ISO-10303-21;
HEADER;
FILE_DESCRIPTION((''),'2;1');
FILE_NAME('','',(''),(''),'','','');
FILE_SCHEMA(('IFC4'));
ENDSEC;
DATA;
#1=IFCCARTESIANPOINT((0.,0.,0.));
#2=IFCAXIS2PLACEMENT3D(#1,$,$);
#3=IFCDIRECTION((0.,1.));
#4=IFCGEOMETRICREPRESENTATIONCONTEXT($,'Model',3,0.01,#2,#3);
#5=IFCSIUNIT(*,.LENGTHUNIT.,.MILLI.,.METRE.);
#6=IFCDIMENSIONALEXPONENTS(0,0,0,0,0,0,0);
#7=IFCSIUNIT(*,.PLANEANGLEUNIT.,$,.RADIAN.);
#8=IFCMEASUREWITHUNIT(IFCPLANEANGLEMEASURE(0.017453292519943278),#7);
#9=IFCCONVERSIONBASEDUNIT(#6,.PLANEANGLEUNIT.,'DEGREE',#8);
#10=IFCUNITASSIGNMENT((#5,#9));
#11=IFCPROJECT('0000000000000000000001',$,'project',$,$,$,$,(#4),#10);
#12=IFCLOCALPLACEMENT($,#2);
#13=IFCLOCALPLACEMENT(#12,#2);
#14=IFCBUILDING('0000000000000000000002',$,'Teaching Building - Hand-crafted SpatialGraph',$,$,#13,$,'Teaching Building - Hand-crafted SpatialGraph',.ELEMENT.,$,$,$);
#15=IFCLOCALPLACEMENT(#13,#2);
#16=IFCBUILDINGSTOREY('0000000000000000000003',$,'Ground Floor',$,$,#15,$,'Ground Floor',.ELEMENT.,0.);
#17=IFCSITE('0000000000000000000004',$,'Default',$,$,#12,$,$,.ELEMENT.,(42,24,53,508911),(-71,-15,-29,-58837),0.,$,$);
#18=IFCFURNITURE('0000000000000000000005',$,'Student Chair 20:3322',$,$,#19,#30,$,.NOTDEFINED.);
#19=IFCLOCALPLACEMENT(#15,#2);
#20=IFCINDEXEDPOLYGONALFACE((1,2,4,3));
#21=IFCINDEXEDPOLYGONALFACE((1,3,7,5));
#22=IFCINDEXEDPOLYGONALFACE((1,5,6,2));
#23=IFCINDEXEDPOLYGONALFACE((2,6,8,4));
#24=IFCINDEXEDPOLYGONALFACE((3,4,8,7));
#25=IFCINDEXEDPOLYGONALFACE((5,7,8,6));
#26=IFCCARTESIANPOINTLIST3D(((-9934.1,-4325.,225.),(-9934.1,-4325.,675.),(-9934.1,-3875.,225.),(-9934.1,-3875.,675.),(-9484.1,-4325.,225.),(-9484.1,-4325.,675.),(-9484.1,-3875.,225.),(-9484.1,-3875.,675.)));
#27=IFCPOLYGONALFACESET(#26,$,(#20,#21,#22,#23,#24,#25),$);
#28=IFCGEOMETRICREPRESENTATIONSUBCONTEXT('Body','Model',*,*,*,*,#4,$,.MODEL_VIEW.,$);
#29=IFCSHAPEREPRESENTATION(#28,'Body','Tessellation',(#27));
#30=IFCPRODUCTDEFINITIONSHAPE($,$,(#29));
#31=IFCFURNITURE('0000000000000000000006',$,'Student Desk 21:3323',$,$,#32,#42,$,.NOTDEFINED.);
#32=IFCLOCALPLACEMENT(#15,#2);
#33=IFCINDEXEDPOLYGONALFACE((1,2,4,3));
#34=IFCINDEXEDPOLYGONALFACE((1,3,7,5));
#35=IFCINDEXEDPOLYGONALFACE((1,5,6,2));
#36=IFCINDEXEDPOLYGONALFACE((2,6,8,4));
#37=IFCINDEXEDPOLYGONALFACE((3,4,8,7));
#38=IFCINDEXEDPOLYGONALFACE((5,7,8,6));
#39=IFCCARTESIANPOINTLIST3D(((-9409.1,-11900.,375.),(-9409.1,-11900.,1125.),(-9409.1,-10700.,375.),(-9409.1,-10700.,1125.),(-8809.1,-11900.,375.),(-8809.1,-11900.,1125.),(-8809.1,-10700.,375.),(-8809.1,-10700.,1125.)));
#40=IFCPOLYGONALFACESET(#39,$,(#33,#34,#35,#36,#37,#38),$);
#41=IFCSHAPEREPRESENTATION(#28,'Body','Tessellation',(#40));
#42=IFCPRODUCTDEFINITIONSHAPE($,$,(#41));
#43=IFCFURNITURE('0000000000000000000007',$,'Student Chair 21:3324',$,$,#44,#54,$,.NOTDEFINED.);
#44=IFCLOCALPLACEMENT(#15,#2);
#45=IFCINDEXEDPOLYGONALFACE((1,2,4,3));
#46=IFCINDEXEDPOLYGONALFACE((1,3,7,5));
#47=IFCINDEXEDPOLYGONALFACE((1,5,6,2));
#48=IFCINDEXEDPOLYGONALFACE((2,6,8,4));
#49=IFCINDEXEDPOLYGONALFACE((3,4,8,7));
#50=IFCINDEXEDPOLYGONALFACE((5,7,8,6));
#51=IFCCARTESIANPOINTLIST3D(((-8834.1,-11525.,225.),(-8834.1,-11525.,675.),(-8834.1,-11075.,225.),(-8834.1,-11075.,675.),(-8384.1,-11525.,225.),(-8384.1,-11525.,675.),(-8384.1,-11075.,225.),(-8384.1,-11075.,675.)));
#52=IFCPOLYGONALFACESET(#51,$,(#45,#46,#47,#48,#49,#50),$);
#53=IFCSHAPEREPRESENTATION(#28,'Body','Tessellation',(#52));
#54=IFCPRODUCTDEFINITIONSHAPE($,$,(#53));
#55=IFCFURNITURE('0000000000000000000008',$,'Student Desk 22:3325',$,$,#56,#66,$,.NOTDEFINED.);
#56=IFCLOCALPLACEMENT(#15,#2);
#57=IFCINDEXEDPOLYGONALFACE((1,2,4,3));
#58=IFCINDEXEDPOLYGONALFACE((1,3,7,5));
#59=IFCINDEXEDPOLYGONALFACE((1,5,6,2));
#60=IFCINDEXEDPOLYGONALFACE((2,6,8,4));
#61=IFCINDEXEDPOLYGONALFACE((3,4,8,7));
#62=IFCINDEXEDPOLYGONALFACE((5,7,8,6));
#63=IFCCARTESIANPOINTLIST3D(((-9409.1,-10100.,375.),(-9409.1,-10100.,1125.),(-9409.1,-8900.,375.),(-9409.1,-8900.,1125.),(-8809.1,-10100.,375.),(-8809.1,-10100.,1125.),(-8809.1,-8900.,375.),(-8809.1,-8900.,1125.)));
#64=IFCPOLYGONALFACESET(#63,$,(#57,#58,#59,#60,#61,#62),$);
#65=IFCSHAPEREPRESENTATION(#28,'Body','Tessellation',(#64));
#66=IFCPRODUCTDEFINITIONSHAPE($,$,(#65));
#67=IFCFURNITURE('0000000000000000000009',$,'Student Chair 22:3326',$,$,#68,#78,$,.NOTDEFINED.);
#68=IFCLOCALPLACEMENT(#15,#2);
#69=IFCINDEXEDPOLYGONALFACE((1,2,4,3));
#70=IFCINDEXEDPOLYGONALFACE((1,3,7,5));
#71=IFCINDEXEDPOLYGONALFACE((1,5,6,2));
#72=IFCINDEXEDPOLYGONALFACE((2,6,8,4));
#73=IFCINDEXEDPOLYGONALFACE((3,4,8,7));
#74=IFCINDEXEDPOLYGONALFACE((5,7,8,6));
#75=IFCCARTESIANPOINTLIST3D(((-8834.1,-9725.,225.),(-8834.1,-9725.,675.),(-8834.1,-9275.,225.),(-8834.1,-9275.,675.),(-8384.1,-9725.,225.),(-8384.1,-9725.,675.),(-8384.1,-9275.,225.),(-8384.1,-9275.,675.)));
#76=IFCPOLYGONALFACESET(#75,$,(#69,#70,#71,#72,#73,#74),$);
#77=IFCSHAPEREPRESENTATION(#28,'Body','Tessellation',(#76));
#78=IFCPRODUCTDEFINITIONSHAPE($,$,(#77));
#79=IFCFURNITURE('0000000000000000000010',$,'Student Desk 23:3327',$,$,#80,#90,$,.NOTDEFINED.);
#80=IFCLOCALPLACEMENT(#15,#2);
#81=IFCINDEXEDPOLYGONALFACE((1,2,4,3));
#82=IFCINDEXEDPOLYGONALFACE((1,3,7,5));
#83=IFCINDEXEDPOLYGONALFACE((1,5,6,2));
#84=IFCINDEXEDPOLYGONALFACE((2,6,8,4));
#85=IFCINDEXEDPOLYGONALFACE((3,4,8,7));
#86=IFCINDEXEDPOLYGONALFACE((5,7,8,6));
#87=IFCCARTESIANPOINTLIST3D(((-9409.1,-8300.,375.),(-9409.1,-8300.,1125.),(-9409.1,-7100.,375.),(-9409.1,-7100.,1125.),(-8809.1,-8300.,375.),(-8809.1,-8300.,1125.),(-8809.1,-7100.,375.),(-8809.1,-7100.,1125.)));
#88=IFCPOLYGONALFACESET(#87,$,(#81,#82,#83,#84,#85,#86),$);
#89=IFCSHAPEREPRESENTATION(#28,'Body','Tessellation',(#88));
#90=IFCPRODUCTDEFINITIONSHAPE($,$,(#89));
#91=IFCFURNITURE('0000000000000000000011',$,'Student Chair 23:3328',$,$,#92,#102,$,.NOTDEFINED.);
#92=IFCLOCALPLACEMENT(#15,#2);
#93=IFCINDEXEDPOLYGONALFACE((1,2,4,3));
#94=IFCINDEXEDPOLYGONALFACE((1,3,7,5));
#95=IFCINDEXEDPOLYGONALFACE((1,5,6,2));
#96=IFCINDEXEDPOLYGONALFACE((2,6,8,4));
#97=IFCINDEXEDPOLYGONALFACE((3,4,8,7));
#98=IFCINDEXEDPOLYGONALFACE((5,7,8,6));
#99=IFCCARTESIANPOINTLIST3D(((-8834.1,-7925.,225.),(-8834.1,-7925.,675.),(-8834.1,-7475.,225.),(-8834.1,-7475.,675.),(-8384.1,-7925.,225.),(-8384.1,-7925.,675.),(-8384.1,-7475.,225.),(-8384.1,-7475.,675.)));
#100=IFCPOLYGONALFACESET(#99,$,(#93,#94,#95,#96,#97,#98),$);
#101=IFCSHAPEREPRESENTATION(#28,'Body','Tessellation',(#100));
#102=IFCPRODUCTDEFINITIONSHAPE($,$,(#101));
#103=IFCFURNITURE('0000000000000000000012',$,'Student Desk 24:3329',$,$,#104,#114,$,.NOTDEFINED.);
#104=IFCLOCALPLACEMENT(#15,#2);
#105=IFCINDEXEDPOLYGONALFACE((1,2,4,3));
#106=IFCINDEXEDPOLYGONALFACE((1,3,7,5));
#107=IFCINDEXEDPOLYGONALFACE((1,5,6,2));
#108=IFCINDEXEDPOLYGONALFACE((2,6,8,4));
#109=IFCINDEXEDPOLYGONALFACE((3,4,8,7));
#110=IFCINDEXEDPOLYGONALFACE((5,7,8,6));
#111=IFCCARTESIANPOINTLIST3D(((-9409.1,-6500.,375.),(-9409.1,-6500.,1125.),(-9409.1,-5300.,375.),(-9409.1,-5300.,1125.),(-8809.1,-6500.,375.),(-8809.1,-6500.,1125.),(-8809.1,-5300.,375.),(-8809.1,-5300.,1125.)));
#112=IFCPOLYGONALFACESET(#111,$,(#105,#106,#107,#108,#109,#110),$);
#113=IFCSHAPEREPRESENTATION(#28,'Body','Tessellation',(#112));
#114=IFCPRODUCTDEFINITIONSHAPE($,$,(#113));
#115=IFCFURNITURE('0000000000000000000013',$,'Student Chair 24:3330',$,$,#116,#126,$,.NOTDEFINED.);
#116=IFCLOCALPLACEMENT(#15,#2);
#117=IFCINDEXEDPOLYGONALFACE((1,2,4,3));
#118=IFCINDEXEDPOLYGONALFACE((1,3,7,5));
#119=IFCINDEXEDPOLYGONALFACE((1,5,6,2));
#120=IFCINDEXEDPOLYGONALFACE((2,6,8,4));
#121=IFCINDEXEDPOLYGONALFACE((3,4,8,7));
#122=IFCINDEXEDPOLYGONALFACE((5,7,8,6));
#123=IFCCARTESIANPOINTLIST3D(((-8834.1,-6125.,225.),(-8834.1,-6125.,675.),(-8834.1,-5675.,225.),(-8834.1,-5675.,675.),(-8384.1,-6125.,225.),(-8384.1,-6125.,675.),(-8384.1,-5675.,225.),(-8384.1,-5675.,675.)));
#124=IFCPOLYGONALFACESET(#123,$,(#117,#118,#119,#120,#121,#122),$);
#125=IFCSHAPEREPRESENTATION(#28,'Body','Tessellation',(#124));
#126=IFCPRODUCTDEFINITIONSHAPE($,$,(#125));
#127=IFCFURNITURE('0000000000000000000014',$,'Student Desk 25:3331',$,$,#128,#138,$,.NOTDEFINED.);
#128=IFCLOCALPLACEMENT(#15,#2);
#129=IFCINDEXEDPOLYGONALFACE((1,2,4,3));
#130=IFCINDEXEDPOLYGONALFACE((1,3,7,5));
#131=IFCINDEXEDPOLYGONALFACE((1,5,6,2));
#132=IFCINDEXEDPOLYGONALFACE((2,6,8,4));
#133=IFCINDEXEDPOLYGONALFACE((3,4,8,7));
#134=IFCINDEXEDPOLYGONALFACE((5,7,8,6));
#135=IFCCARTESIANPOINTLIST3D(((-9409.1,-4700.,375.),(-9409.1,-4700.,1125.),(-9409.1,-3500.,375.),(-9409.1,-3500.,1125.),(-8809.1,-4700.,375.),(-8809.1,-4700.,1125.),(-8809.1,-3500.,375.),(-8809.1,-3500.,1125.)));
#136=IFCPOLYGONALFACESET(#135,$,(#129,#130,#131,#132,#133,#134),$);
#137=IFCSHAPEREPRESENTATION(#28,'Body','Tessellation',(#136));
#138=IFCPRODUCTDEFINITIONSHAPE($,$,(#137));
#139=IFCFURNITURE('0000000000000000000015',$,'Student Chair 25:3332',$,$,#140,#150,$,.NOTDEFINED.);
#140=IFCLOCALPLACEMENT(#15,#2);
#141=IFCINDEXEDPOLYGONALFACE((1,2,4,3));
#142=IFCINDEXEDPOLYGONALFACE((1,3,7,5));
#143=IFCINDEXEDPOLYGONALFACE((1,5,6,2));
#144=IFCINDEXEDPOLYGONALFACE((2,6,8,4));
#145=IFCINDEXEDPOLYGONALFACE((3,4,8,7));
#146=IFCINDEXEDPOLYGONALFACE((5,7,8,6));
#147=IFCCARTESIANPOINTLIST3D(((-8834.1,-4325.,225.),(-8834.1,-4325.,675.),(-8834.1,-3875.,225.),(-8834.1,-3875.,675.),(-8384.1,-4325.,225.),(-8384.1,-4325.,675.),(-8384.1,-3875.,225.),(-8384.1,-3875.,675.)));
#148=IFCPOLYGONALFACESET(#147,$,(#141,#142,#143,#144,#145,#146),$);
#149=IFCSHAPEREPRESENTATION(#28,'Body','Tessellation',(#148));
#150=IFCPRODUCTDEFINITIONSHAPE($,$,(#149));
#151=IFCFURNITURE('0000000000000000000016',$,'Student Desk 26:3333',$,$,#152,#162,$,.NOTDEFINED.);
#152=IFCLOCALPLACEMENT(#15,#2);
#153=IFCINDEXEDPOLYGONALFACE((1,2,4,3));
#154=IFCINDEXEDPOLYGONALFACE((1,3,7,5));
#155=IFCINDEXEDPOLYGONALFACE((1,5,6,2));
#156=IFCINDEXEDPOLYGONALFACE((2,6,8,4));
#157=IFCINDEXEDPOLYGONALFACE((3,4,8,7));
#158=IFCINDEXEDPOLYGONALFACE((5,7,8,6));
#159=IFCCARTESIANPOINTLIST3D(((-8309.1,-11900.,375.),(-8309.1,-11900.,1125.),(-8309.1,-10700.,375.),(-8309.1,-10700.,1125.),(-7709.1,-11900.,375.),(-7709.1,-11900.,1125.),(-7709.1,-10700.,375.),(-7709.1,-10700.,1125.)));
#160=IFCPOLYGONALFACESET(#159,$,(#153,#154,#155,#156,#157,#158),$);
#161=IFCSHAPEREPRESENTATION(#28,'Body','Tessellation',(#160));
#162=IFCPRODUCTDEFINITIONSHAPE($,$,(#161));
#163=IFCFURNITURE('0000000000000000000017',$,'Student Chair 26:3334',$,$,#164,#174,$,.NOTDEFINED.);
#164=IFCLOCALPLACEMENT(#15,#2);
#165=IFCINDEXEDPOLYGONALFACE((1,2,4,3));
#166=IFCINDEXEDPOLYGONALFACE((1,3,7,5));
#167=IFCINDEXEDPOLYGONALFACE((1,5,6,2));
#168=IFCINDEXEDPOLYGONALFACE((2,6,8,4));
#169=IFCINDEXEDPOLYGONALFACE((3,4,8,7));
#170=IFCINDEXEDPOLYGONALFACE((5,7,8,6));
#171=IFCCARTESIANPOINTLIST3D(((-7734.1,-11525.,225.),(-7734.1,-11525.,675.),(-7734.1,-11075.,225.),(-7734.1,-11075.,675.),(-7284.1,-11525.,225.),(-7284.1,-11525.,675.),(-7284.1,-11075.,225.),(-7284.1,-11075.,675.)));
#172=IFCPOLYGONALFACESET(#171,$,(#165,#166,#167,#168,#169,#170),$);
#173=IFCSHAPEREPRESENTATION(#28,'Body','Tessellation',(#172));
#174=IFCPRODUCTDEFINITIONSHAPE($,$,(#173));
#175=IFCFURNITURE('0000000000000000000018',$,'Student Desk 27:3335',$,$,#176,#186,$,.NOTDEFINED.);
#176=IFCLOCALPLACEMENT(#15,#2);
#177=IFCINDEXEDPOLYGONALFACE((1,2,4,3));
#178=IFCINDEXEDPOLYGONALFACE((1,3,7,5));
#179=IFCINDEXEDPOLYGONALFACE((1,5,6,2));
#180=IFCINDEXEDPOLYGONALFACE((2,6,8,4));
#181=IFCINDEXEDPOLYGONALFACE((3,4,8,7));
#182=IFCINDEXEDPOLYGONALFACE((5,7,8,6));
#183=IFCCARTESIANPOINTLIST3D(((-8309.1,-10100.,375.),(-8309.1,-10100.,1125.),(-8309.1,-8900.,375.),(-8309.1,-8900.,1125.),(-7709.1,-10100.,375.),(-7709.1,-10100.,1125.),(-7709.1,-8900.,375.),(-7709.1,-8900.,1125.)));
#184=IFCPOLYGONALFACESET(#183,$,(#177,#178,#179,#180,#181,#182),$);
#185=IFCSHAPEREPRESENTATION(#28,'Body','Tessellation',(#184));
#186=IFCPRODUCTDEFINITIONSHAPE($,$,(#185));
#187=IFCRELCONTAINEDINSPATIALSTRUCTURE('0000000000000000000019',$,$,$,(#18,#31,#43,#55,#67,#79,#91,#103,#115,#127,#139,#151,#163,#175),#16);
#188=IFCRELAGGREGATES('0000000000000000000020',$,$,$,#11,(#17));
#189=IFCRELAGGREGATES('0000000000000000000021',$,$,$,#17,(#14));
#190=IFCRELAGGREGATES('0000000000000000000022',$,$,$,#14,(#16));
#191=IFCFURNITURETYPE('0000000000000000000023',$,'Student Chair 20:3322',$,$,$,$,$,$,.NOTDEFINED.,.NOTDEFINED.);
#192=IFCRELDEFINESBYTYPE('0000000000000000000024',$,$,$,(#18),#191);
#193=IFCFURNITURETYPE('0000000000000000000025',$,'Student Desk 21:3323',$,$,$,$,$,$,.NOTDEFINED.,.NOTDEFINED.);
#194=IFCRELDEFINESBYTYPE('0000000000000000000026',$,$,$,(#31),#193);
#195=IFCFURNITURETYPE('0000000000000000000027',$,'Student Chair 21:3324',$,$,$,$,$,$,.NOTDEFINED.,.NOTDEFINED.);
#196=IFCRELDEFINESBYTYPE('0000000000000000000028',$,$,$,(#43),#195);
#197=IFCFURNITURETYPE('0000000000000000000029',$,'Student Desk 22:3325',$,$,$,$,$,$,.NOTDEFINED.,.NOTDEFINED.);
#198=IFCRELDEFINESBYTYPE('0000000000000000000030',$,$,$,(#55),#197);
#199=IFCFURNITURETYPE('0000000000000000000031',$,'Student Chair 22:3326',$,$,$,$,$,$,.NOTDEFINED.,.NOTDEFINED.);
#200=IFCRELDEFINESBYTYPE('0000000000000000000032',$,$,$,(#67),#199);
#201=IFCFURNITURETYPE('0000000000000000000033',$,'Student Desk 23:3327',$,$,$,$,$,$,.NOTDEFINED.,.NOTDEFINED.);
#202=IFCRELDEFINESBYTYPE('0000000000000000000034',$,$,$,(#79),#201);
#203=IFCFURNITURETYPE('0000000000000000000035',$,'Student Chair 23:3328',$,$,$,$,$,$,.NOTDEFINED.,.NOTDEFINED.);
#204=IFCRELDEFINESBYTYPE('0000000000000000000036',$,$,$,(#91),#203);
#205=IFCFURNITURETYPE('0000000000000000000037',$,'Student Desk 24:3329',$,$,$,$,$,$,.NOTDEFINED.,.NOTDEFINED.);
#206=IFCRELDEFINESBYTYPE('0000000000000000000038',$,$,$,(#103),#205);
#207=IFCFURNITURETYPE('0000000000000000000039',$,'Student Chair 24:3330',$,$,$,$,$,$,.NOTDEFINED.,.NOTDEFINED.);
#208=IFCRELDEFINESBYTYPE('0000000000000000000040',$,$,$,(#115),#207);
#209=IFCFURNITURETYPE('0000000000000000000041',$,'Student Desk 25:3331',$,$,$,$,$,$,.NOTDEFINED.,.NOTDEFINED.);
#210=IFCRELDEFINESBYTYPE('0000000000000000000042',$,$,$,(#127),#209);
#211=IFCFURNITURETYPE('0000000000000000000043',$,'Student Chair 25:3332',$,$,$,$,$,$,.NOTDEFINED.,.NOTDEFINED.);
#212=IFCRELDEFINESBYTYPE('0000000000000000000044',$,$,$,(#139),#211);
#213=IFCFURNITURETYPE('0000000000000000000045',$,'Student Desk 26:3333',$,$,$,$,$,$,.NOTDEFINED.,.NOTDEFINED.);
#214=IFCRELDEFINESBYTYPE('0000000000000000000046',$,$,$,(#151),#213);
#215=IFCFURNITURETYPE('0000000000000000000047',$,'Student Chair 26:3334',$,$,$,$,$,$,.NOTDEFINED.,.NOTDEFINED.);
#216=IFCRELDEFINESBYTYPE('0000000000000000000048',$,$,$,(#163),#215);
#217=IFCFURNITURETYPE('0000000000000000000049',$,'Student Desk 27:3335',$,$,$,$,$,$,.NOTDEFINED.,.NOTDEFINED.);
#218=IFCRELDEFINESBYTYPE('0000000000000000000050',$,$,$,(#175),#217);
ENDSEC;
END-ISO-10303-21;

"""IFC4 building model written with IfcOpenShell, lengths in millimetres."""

from ifc_helpers import new_model, entity, si_unit, converted_unit, direction, frame, frame_2d, origin, origin_2d_with_axis, place, context, subcontext, project, spatial, rectangle, extrude, type_object, element, save


model = new_model("IFC4")

# Units and contexts
model_context = context("Model", 3, precision=0.01, world=origin(), true_north=direction((0.0, 1.0)))
body_context = subcontext(model_context, "Body", "Model", "MODEL_VIEW")
ifc_project = project(units=[si_unit("LENGTHUNIT", "METRE", prefix="MILLI"), converted_unit("PLANEANGLEUNIT", "DEGREE", entity("IfcPlaneAngleMeasure", 0.017453292519943278), si_unit("PLANEANGLEUNIT", "RADIAN"), dimensions=[0, 0, 0, 0, 0, 0, 0])], contexts=[model_context])

# Site, building, storey
site_placement = place(None, origin())
site = spatial("IfcSite", under=ifc_project, at=site_placement, Name="Default", CompositionType="ELEMENT", RefLatitude=(42, 24, 53, 508911), RefLongitude=(-71, -15, -29, -58837), RefElevation=0.0)
building_placement = place(site_placement, origin())
building = spatial("IfcBuilding", under=site, at=building_placement, Name="Teaching Building - Hand-crafted SpatialGraph", LongName="Teaching Building - Hand-crafted SpatialGraph", CompositionType="ELEMENT")
storey_placement = place(building_placement, origin())
storey = spatial("IfcBuildingStorey", under=building, at=storey_placement, Name="Ground Floor", LongName="Ground Floor", CompositionType="ELEMENT", Elevation=0.0)

# Furniture
furniture_type_1 = type_object("IfcFurnitureType", Name="Student Chair 20:3322", PredefinedType="NOTDEFINED")
furniture_1_placement = place(storey_placement, origin())
element("IfcFurniture", 1, at=furniture_1_placement, inside=storey, type_object=furniture_type_1, Name="Student Chair 20:3322", PredefinedType="NOTDEFINED", context=body_context, shape_type="SweptSolid", body=[
    extrude(rectangle(XDim=450.0, YDim=450.0, at=frame_2d((0.0, 0.0), x_axis=(1.0, 0.0))), frame((-9709.1, -4100.0, 225.0)), (0.0, 0.0, 1.0), 450.0),
])
furniture_type_2 = type_object("IfcFurnitureType", Name="Student Desk 21:3323", PredefinedType="NOTDEFINED")
furniture_2_placement = place(storey_placement, origin())
element("IfcFurniture", 2, at=furniture_2_placement, inside=storey, type_object=furniture_type_2, Name="Student Desk 21:3323", PredefinedType="NOTDEFINED", context=body_context, shape_type="SweptSolid", body=[
    extrude(rectangle(XDim=1200.0, YDim=600.0, at=origin_2d_with_axis()), frame((-9109.1, -11300.0, 375.0), z_axis=(0.0, 0.0, 1.0), x_axis=(0.0, 1.0, 0.0)), (0.0, 0.0, 1.0), 750.0),
])
furniture_type_3 = type_object("IfcFurnitureType", Name="Student Chair 21:3324", PredefinedType="NOTDEFINED")
furniture_3_placement = place(storey_placement, origin())
element("IfcFurniture", 3, at=furniture_3_placement, inside=storey, type_object=furniture_type_3, Name="Student Chair 21:3324", PredefinedType="NOTDEFINED", context=body_context, shape_type="SweptSolid", body=[
    extrude(rectangle(XDim=450.0, YDim=450.0, at=origin_2d_with_axis()), frame((-8609.1, -11300.0, 225.0)), (0.0, 0.0, 1.0), 450.0),
])
furniture_type_4 = type_object("IfcFurnitureType", Name="Student Desk 22:3325", PredefinedType="NOTDEFINED")
furniture_4_placement = place(storey_placement, origin())
element("IfcFurniture", 4, at=furniture_4_placement, inside=storey, type_object=furniture_type_4, Name="Student Desk 22:3325", PredefinedType="NOTDEFINED", context=body_context, shape_type="SweptSolid", body=[
    extrude(rectangle(XDim=1200.0, YDim=600.0, at=origin_2d_with_axis()), frame((-9109.1, -9500.0, 375.0), z_axis=(0.0, 0.0, 1.0), x_axis=(0.0, 1.0, 0.0)), (0.0, 0.0, 1.0), 750.0),
])
furniture_type_5 = type_object("IfcFurnitureType", Name="Student Chair 22:3326", PredefinedType="NOTDEFINED")
furniture_5_placement = place(storey_placement, origin())
element("IfcFurniture", 5, at=furniture_5_placement, inside=storey, type_object=furniture_type_5, Name="Student Chair 22:3326", PredefinedType="NOTDEFINED", context=body_context, shape_type="SweptSolid", body=[
    extrude(rectangle(XDim=450.0, YDim=450.0, at=origin_2d_with_axis()), frame((-8609.1, -9500.0, 225.0)), (0.0, 0.0, 1.0), 450.0),
])
furniture_type_6 = type_object("IfcFurnitureType", Name="Student Desk 23:3327", PredefinedType="NOTDEFINED")
furniture_6_placement = place(storey_placement, origin())
element("IfcFurniture", 6, at=furniture_6_placement, inside=storey, type_object=furniture_type_6, Name="Student Desk 23:3327", PredefinedType="NOTDEFINED", context=body_context, shape_type="SweptSolid", body=[
    extrude(rectangle(XDim=1200.0, YDim=600.0, at=origin_2d_with_axis()), frame((-9109.1, -7700.0, 375.0), z_axis=(0.0, 0.0, 1.0), x_axis=(0.0, 1.0, 0.0)), (0.0, 0.0, 1.0), 750.0),
])
furniture_type_7 = type_object("IfcFurnitureType", Name="Student Chair 23:3328", PredefinedType="NOTDEFINED")
furniture_7_placement = place(storey_placement, origin())
element("IfcFurniture", 7, at=furniture_7_placement, inside=storey, type_object=furniture_type_7, Name="Student Chair 23:3328", PredefinedType="NOTDEFINED", context=body_context, shape_type="SweptSolid", body=[
    extrude(rectangle(XDim=450.0, YDim=450.0, at=frame_2d((0.0, 0.0), x_axis=(1.0, 0.0))), frame((-8609.1, -7700.0, 225.0)), (0.0, 0.0, 1.0), 450.0),
])
furniture_type_8 = type_object("IfcFurnitureType", Name="Student Desk 24:3329", PredefinedType="NOTDEFINED")
furniture_8_placement = place(storey_placement, origin())
element("IfcFurniture", 8, at=furniture_8_placement, inside=storey, type_object=furniture_type_8, Name="Student Desk 24:3329", PredefinedType="NOTDEFINED", context=body_context, shape_type="SweptSolid", body=[
    extrude(rectangle(XDim=1200.0, YDim=600.0, at=origin_2d_with_axis()), frame((-9109.1, -5900.0, 375.0), z_axis=(0.0, 0.0, 1.0), x_axis=(0.0, 1.0, 0.0)), (0.0, 0.0, 1.0), 750.0),
])
furniture_type_9 = type_object("IfcFurnitureType", Name="Student Chair 24:3330", PredefinedType="NOTDEFINED")
furniture_9_placement = place(storey_placement, origin())
element("IfcFurniture", 9, at=furniture_9_placement, inside=storey, type_object=furniture_type_9, Name="Student Chair 24:3330", PredefinedType="NOTDEFINED", context=body_context, shape_type="SweptSolid", body=[
    extrude(rectangle(XDim=450.0, YDim=450.0, at=origin_2d_with_axis()), frame((-8609.1, -5900.0, 225.0)), (0.0, 0.0, 1.0), 450.0),
])
furniture_type_10 = type_object("IfcFurnitureType", Name="Student Desk 25:3331", PredefinedType="NOTDEFINED")
furniture_10_placement = place(storey_placement, origin())
element("IfcFurniture", 10, at=furniture_10_placement, inside=storey, type_object=furniture_type_10, Name="Student Desk 25:3331", PredefinedType="NOTDEFINED", context=body_context, shape_type="SweptSolid", body=[
    extrude(rectangle(XDim=1200.0, YDim=600.0, at=origin_2d_with_axis()), frame((-9109.1, -4100.0, 375.0), z_axis=(0.0, 0.0, 1.0), x_axis=(0.0, 1.0, 0.0)), (0.0, 0.0, 1.0), 750.0),
])
furniture_type_11 = type_object("IfcFurnitureType", Name="Student Chair 25:3332", PredefinedType="NOTDEFINED")
furniture_11_placement = place(storey_placement, origin())
element("IfcFurniture", 11, at=furniture_11_placement, inside=storey, type_object=furniture_type_11, Name="Student Chair 25:3332", PredefinedType="NOTDEFINED", context=body_context, shape_type="SweptSolid", body=[
    extrude(rectangle(XDim=450.0, YDim=450.0, at=origin_2d_with_axis()), frame((-8609.1, -4100.0, 225.0)), (0.0, 0.0, 1.0), 450.0),
])
furniture_type_12 = type_object("IfcFurnitureType", Name="Student Desk 26:3333", PredefinedType="NOTDEFINED")
furniture_12_placement = place(storey_placement, origin())
element("IfcFurniture", 12, at=furniture_12_placement, inside=storey, type_object=furniture_type_12, Name="Student Desk 26:3333", PredefinedType="NOTDEFINED", context=body_context, shape_type="SweptSolid", body=[
    extrude(rectangle(XDim=1200.0, YDim=600.0, at=frame_2d((0.0, 0.0), x_axis=(1.0, 0.0))), frame((-8009.1, -11300.0, 375.0), z_axis=(0.0, 0.0, 1.0), x_axis=(0.0, 1.0, 0.0)), (0.0, 0.0, 1.0), 750.0),
])
furniture_type_13 = type_object("IfcFurnitureType", Name="Student Chair 26:3334", PredefinedType="NOTDEFINED")
furniture_13_placement = place(storey_placement, origin())
element("IfcFurniture", 13, at=furniture_13_placement, inside=storey, type_object=furniture_type_13, Name="Student Chair 26:3334", PredefinedType="NOTDEFINED", context=body_context, shape_type="SweptSolid", body=[
    extrude(rectangle(XDim=450.0, YDim=450.0, at=origin_2d_with_axis()), frame((-7509.1, -11300.0, 225.0)), (0.0, 0.0, 1.0), 450.0),
])
furniture_type_14 = type_object("IfcFurnitureType", Name="Student Desk 27:3335", PredefinedType="NOTDEFINED")
furniture_14_placement = place(storey_placement, origin())
element("IfcFurniture", 14, at=furniture_14_placement, inside=storey, type_object=furniture_type_14, Name="Student Desk 27:3335", PredefinedType="NOTDEFINED", context=body_context, shape_type="SweptSolid", body=[
    extrude(rectangle(XDim=1200.0, YDim=600.0, at=frame_2d((0.0, 0.0), x_axis=(1.0, 0.0))), frame((-8009.1, -9500.0, 375.0), z_axis=(0.0, 0.0, 1.0), x_axis=(0.0, 1.0, 0.0)), (0.0, 0.0, 1.0), 750.0),
])

save(model, "model.ifc")
